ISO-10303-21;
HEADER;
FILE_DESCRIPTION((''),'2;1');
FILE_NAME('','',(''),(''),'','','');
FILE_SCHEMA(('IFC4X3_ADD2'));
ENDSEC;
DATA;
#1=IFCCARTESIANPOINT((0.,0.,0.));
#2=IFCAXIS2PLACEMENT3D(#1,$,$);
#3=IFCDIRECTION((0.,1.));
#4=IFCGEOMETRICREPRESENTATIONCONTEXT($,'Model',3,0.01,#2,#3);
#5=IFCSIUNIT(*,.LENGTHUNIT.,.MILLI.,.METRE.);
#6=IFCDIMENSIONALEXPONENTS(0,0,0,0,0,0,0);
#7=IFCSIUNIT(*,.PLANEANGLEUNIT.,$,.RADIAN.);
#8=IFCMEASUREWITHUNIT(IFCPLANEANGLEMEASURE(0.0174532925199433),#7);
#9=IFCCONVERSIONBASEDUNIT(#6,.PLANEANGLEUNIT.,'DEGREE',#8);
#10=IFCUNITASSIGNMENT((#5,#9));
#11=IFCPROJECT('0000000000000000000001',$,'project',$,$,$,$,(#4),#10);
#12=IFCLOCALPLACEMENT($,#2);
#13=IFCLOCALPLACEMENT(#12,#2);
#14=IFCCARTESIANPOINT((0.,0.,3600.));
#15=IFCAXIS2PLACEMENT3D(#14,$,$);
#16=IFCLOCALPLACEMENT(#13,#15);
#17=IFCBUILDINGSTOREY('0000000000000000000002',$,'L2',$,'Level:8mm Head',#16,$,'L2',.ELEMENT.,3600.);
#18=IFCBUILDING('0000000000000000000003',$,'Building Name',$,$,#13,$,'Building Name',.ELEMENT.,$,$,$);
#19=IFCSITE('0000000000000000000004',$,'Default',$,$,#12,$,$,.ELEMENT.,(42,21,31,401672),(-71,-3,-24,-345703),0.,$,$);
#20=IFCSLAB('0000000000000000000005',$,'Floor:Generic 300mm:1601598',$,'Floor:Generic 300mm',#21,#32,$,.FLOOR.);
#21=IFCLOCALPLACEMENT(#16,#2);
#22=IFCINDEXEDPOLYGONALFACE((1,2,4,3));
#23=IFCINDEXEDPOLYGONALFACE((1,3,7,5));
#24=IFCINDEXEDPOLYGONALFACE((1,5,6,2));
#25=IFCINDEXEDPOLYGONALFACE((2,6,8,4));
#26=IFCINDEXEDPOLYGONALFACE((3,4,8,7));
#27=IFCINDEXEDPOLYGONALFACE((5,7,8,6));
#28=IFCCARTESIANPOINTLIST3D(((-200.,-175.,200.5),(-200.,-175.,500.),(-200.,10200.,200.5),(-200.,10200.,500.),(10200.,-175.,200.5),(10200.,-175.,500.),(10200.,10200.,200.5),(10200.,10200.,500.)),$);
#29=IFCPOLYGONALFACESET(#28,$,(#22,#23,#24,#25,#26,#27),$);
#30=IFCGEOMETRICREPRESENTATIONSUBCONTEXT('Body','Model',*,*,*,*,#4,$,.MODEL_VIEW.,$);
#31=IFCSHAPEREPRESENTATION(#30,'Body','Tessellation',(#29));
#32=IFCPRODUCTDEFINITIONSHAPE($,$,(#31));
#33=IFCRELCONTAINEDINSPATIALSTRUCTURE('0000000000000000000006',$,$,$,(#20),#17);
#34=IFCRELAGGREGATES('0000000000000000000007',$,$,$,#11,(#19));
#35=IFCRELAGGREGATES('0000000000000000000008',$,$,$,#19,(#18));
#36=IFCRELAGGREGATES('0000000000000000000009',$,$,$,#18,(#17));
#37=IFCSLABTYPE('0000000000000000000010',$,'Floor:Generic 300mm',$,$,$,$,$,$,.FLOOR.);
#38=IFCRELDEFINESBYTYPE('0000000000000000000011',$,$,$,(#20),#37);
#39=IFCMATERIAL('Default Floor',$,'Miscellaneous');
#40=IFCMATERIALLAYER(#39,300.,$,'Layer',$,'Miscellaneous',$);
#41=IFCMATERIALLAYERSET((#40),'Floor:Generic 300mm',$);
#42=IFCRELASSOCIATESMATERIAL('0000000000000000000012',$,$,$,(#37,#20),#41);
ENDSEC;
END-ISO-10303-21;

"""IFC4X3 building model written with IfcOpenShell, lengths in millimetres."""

from ifc_helpers import new_model, entity, si_unit, converted_unit, direction, frame, frame_2d, origin, place, context, subcontext, project, spatial, rectangle, extrude, material, layer, layer_set, layer_usage, type_object, element, save


model = new_model("IFC4X3")

# Units and contexts
model_context = context("Model", 3, precision=0.01, world=origin(), true_north=direction((0.0, 1.0)))
body_context = subcontext(model_context, "Body", "Model", "MODEL_VIEW")
ifc_project = project(units=[si_unit("LENGTHUNIT", "METRE", prefix="MILLI"), converted_unit("PLANEANGLEUNIT", "DEGREE", entity("IfcPlaneAngleMeasure", 0.0174532925199433), si_unit("PLANEANGLEUNIT", "RADIAN"), dimensions=[0, 0, 0, 0, 0, 0, 0])], contexts=[model_context])

# Site, building, storey
site_placement = place(None, origin())
site = spatial("IfcSite", under=ifc_project, at=site_placement, Name="Default", CompositionType="ELEMENT", RefLatitude=(42, 21, 31, 401672), RefLongitude=(-71, -3, -24, -345703), RefElevation=0.0)
building_placement = place(site_placement, origin())
building = spatial("IfcBuilding", under=site, at=building_placement, Name="Building Name", LongName="Building Name", CompositionType="ELEMENT")
storey_placement = place(building_placement, frame((0.0, 0.0, 3600.0)))
storey = spatial("IfcBuildingStorey", under=building, at=storey_placement, Name="L2", ObjectType="Level:8mm Head", LongName="L2", CompositionType="ELEMENT", Elevation=3600.0)

# Slab
ifc_material = material(Name="Default Floor", Category="Miscellaneous")
ifc_layer = layer(ifc_material, 300.0, Name="Layer", Category="Miscellaneous")
ifc_layer_set = layer_set([ifc_layer], Name="Floor:Generic 300mm")
ifc_layer_usage = layer_usage(ifc_layer_set, "AXIS3", "POSITIVE", 0.0)
slab_type = type_object("IfcSlabType", Name="Floor:Generic 300mm", PredefinedType="FLOOR", material=ifc_layer_set)
slab_placement = place(storey_placement, origin())
element("IfcSlab", 1, at=slab_placement, inside=storey, type_object=slab_type, material=ifc_layer_usage, Name="Floor:Generic 300mm:1601598", ObjectType="Floor:Generic 300mm", PredefinedType="FLOOR", context=body_context, shape_type="SweptSolid", body=[
    extrude(rectangle(XDim=10375.0, YDim=10400.0, at=frame_2d((0.0, 0.0), x_axis=(1.0, 0.0))), frame((5000.0, 5012.5, 500.0), z_axis=(0.0, 0.0, -1.0), x_axis=(0.0, 1.0, 0.0)), (0.0, 0.0, 1.0), 299.5),
])

save(model, "model.ifc")
